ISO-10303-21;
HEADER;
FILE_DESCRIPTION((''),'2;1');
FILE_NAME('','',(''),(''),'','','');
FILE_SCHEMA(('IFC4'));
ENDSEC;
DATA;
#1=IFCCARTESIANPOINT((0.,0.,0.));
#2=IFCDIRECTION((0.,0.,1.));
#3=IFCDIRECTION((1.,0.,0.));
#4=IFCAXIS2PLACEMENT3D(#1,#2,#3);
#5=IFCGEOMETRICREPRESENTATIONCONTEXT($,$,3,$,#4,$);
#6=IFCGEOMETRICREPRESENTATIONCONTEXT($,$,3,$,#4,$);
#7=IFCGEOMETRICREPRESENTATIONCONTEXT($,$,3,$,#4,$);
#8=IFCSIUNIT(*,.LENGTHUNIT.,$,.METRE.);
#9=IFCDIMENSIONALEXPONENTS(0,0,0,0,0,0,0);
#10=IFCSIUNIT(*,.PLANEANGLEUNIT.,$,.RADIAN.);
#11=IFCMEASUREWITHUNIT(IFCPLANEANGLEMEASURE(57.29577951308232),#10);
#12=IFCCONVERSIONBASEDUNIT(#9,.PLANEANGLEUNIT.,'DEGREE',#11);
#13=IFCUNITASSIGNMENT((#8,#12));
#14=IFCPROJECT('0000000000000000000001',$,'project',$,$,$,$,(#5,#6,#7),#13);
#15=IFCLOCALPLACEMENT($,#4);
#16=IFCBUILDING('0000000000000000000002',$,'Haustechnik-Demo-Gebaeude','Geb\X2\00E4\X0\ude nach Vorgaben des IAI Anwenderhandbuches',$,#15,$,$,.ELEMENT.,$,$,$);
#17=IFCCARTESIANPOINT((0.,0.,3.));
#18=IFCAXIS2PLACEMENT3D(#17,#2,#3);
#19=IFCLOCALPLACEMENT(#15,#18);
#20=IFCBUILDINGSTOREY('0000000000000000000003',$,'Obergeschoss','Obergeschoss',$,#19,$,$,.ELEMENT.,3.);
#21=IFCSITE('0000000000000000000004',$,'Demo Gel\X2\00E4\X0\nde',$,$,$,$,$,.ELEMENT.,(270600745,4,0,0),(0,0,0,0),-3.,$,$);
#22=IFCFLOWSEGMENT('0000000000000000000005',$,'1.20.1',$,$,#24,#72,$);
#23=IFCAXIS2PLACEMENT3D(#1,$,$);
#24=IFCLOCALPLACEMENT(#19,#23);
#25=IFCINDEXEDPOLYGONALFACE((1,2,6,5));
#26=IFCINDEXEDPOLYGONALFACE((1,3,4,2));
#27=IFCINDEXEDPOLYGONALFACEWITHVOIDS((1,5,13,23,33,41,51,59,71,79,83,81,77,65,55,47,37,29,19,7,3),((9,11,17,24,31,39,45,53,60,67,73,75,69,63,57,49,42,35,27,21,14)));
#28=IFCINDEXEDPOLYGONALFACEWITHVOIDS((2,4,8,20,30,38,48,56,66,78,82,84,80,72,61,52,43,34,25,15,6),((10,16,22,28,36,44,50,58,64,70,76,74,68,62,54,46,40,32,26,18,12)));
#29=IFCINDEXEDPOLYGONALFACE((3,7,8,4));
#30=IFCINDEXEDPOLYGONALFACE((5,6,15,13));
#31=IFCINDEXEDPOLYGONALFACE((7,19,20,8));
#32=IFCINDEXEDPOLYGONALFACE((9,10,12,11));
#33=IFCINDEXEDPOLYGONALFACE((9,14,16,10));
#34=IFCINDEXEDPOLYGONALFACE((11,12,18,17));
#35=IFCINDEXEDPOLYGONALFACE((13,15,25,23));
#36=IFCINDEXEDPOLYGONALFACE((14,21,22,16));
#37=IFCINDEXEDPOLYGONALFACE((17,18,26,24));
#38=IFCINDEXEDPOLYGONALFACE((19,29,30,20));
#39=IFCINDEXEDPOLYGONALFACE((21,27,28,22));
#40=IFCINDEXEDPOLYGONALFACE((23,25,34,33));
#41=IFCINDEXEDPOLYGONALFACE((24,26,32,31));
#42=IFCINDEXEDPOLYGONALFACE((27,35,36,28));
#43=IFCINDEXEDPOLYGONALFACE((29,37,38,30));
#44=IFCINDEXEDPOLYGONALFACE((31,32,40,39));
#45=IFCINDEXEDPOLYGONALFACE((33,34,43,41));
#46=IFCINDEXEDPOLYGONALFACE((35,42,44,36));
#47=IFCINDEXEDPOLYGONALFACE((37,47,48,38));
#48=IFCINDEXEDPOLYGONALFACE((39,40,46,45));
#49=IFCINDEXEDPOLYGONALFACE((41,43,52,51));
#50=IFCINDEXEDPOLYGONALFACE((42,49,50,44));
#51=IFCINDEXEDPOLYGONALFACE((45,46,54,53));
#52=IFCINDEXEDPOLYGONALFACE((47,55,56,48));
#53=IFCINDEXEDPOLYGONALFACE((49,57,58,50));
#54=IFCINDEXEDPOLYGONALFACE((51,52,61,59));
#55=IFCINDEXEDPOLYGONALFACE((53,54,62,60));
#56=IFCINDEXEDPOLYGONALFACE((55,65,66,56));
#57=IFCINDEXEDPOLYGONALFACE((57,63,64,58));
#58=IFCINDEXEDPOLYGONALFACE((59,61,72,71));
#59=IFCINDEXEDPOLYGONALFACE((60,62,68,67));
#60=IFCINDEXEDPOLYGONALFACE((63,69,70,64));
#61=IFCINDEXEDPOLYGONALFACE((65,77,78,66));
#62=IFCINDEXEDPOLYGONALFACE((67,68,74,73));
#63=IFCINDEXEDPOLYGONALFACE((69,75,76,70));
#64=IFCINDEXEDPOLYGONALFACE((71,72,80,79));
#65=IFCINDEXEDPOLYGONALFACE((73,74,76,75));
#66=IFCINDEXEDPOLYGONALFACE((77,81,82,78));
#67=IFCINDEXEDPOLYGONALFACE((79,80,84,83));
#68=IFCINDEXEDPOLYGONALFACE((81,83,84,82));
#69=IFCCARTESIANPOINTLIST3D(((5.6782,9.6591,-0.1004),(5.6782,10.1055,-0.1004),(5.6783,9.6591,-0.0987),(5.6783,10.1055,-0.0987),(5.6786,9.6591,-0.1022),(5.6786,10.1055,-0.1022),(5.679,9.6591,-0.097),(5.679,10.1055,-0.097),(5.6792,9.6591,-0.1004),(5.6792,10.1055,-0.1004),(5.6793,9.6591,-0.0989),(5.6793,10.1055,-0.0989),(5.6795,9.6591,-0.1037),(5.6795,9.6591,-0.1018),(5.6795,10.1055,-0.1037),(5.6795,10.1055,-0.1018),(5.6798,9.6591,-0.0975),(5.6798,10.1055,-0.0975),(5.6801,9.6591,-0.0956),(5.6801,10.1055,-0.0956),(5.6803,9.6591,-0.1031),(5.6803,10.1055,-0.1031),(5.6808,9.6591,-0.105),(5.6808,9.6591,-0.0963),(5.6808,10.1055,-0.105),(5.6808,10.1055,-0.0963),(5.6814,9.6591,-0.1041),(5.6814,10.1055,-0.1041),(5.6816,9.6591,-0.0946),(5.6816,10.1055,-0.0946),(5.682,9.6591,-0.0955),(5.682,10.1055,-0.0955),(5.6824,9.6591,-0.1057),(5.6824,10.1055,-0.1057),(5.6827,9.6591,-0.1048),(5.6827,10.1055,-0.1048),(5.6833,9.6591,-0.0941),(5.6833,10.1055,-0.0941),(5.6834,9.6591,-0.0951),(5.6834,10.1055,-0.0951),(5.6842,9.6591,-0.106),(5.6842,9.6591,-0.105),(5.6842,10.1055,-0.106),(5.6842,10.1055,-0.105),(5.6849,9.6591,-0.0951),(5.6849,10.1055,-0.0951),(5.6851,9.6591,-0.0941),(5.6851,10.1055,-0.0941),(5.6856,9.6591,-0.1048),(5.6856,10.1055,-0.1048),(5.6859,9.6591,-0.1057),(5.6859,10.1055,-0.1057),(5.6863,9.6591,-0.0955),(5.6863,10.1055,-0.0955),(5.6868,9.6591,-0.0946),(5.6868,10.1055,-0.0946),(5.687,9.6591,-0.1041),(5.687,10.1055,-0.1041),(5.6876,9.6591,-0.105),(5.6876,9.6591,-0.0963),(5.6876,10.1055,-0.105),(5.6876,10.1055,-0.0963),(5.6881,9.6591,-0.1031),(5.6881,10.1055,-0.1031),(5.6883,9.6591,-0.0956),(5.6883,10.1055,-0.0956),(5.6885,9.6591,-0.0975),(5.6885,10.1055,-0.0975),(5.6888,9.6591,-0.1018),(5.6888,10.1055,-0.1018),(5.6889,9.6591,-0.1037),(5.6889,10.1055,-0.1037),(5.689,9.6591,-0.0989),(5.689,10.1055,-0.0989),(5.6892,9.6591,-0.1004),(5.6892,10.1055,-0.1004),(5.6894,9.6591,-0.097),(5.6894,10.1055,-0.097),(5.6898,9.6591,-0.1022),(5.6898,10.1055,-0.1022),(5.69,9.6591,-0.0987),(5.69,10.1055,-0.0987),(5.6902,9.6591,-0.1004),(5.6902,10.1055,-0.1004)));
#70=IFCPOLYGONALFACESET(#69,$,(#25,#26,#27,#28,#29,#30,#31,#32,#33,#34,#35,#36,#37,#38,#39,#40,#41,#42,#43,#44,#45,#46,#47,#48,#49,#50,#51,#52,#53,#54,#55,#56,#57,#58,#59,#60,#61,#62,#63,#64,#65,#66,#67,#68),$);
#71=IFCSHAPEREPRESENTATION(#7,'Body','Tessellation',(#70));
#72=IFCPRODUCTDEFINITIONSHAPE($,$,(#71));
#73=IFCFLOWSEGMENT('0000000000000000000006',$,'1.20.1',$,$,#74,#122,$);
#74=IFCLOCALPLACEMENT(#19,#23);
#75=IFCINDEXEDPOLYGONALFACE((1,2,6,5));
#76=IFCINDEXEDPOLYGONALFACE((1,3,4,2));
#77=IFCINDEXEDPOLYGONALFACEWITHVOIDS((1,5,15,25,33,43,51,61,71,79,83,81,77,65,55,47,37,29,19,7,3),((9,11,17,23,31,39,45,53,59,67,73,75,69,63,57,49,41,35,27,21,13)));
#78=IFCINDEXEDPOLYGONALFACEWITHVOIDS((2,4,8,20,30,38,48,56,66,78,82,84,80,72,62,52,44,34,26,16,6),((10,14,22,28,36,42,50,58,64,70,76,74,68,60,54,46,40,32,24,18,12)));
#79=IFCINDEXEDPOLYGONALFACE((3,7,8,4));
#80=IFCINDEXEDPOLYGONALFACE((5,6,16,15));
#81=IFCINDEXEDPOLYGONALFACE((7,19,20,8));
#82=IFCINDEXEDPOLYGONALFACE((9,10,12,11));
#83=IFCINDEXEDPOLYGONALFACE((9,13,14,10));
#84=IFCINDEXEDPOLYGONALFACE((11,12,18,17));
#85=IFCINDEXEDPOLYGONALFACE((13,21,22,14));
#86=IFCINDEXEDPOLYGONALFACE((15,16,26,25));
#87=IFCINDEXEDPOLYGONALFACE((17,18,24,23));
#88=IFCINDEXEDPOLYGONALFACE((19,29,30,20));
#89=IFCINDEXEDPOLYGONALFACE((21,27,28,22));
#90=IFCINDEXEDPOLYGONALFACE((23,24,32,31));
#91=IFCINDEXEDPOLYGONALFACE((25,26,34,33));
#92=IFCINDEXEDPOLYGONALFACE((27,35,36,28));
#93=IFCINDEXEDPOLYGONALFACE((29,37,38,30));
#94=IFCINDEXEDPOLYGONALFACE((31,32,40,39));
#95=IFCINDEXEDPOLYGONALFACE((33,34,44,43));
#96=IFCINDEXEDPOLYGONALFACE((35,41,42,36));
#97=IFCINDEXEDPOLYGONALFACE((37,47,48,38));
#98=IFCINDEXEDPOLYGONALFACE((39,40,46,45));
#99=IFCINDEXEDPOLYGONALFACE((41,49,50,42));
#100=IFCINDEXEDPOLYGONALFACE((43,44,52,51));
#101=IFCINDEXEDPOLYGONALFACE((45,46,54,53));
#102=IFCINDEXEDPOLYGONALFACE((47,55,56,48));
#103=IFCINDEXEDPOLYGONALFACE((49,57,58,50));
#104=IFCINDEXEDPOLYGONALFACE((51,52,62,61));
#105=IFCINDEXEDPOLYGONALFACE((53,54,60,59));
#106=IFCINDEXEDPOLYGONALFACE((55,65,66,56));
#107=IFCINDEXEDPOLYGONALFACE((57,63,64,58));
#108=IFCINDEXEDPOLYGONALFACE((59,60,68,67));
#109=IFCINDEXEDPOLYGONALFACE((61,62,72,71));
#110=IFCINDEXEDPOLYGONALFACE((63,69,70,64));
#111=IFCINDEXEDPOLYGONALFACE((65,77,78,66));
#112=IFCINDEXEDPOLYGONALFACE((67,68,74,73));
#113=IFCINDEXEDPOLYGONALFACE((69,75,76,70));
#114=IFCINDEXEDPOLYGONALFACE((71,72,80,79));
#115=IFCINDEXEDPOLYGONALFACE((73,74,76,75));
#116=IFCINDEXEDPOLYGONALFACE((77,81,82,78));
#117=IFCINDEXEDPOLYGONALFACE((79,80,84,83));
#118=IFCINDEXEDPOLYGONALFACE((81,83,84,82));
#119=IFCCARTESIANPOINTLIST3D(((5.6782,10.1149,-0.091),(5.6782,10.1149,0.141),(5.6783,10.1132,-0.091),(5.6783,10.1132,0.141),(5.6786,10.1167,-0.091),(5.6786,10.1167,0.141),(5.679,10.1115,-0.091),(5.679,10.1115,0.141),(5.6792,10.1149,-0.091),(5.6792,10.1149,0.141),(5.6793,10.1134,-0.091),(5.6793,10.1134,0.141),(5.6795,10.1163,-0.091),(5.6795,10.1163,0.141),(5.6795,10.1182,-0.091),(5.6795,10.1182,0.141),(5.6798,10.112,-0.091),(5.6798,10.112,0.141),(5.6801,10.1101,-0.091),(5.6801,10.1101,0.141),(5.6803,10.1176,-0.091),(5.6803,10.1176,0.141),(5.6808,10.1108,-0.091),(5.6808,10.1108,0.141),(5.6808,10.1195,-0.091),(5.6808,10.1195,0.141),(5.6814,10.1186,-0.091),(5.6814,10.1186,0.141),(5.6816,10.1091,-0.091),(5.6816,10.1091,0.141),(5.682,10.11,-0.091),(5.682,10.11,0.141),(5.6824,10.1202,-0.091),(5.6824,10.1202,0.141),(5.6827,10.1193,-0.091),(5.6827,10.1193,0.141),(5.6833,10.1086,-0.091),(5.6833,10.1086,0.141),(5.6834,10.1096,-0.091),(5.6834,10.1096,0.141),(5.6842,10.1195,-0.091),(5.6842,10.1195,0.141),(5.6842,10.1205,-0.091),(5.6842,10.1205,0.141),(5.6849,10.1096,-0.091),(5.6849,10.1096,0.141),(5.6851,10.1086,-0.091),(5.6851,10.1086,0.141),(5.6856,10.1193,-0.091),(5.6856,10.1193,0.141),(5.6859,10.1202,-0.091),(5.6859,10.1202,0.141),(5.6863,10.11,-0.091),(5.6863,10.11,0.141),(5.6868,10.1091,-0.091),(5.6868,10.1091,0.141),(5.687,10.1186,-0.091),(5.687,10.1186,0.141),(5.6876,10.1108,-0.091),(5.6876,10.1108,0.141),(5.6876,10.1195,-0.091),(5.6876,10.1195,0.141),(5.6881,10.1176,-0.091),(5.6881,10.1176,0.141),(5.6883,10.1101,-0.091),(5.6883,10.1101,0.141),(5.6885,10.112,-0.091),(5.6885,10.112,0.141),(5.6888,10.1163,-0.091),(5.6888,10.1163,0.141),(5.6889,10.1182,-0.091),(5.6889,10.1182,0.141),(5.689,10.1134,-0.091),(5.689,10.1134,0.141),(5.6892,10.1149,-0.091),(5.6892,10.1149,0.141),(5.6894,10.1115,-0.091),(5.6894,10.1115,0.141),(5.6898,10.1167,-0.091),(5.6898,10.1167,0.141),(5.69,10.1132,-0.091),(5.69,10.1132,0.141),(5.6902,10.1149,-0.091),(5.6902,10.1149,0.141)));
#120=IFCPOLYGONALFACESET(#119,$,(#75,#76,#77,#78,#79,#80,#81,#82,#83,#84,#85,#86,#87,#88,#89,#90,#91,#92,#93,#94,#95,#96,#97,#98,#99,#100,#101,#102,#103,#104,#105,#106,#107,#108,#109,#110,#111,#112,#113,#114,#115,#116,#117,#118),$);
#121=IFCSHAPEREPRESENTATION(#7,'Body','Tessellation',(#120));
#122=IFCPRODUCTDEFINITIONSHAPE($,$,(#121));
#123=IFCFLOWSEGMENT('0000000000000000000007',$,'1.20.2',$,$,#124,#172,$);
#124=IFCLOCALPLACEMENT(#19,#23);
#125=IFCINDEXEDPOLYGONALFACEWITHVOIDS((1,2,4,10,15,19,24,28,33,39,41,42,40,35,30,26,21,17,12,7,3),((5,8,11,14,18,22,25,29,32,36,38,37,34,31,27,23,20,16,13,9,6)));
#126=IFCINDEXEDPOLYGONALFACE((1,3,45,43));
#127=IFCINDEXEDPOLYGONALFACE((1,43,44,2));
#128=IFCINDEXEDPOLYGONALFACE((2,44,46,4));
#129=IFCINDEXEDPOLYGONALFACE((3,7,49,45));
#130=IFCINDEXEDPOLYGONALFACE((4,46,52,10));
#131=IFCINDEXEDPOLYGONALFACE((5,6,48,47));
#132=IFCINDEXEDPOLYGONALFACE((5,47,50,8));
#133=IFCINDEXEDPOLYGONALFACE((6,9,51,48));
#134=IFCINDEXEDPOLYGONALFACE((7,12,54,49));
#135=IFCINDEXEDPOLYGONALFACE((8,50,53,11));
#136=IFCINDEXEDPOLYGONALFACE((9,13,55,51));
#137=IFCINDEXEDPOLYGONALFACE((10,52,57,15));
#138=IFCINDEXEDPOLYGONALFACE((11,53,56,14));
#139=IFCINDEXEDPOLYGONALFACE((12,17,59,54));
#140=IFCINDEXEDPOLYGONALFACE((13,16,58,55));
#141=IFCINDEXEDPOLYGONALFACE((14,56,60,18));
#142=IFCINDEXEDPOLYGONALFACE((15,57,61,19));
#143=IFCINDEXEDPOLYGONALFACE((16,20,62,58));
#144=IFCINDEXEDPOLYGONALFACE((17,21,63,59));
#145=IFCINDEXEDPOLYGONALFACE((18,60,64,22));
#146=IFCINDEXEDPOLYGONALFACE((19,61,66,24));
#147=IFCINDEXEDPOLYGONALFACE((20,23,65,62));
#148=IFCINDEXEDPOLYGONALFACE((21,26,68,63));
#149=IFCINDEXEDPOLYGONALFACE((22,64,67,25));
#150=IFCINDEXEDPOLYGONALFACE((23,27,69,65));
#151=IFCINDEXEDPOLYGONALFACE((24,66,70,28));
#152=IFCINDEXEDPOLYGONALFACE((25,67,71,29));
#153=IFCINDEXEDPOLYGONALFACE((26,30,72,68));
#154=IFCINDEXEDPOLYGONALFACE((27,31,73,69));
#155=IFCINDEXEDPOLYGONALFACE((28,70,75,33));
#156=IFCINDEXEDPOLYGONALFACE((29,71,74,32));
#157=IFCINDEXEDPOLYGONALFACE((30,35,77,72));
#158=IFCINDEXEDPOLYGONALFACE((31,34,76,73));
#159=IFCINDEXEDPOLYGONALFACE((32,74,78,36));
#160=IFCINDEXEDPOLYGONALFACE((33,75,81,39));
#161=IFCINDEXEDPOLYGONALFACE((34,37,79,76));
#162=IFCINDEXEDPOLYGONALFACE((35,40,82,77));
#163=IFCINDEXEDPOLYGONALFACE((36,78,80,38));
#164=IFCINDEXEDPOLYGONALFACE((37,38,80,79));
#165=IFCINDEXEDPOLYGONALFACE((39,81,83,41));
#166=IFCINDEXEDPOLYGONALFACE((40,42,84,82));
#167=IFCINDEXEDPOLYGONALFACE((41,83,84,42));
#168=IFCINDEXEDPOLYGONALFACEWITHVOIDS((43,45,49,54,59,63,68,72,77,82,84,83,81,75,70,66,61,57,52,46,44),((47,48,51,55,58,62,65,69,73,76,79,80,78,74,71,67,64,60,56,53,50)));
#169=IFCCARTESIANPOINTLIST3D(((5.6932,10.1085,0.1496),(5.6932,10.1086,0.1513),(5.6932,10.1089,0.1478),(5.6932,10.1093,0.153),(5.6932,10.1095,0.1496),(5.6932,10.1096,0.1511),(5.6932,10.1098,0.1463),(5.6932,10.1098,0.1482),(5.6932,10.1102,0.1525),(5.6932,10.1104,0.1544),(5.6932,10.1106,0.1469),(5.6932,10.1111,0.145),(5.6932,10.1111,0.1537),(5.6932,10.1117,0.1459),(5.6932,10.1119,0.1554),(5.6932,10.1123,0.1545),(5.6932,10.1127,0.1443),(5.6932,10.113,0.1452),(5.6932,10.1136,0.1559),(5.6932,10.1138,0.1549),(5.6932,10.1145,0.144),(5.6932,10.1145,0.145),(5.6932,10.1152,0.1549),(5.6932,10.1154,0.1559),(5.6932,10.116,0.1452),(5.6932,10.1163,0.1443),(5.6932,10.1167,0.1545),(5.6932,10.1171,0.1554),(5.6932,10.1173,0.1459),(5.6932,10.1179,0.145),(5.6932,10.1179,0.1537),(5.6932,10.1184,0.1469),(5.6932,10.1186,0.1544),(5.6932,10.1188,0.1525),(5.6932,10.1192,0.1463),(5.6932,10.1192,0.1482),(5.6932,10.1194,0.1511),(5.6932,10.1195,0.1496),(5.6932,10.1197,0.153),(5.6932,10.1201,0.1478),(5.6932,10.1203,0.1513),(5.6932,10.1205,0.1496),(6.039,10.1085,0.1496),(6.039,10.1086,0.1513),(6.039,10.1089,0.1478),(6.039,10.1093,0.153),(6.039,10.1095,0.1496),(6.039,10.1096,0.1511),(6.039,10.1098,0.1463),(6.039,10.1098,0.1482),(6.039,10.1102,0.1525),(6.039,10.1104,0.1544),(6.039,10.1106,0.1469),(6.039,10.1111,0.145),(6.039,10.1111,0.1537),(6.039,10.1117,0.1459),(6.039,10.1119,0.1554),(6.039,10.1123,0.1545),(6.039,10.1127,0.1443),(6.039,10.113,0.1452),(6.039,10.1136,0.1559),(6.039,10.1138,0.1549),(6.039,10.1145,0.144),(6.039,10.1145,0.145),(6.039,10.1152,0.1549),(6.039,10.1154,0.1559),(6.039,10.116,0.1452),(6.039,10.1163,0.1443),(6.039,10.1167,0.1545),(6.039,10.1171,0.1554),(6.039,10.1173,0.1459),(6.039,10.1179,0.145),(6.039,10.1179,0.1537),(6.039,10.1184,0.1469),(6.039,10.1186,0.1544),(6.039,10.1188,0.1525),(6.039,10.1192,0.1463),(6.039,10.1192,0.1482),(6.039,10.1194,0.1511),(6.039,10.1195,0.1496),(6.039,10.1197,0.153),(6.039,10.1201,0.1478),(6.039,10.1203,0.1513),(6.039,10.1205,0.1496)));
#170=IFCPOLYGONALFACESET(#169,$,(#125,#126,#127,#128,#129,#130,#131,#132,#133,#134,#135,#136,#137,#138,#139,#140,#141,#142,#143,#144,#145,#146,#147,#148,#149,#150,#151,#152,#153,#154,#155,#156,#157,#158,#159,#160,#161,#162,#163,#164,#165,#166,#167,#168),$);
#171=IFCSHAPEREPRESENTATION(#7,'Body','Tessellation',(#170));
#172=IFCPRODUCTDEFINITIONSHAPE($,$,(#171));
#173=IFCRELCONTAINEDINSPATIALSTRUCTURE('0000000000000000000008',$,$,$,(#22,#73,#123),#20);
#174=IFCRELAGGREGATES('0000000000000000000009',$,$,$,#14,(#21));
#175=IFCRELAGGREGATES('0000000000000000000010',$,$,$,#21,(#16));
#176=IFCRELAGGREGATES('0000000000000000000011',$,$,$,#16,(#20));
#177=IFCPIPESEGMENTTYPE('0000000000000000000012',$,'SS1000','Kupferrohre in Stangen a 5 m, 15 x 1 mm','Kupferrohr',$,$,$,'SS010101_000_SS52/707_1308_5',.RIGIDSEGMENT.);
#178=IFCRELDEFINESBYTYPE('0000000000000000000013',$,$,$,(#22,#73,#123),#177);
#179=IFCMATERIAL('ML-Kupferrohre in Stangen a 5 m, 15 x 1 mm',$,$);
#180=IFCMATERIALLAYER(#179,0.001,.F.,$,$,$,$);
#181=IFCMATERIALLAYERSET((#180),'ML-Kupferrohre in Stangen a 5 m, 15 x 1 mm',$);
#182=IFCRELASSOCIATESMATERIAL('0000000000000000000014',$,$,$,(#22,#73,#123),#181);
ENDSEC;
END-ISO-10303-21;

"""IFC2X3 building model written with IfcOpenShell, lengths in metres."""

from ifc_helpers import new_model, entity, si_unit, converted_unit, frame, origin_with_axes, origin_2d_with_axis, place, context, project, spatial, hollow_circle, extrude, material, layer, layer_set, layer_usage, type_object, element, save


model = new_model("IFC2X3")

# Units and contexts
context_of_model_1 = context(None, 3, world=origin_with_axes())
context_of_model_2 = context(None, 3, world=origin_with_axes())
context_of_model_3 = context(None, 3, world=origin_with_axes())
ifc_project = project(units=[si_unit("LENGTHUNIT", "METRE"), converted_unit("PLANEANGLEUNIT", "DEGREE", entity("IfcPlaneAngleMeasure", 57.29577951308232), si_unit("PLANEANGLEUNIT", "RADIAN"), dimensions=[0, 0, 0, 0, 0, 0, 0])], contexts=[context_of_model_1, context_of_model_2, context_of_model_3])

# Site, building, storey
site = spatial("IfcSite", under=ifc_project, Name="Demo Gelände", CompositionType="ELEMENT", RefLatitude=(270600745, 4, 0, 0), RefLongitude=(0, 0, 0, 0), RefElevation=-3.0)
building_placement = place(None, origin_with_axes())
building = spatial("IfcBuilding", under=site, at=building_placement, Name="Haustechnik-Demo-Gebaeude", Description="Gebäude nach Vorgaben des IAI Anwenderhandbuches", CompositionType="ELEMENT")
storey_placement = place(building_placement, frame((0.0, 0.0, 3.0), z_axis=(0.0, 0.0, 1.0), x_axis=(1.0, 0.0, 0.0)))
storey = spatial("IfcBuildingStorey", under=building, at=storey_placement, Name="Obergeschoss", Description="Obergeschoss", CompositionType="ELEMENT", Elevation=3.0)

# Flow segments
ifc_material_1 = material(Name="ML-Kupferrohre in Stangen a 5 m, 15 x 1 mm")
ifc_layer_1 = layer(ifc_material_1, 0.001, ventilated=False)
ifc_layer_set_1 = layer_set([ifc_layer_1], Name="ML-Kupferrohre in Stangen a 5 m, 15 x 1 mm")
ifc_layer_usage_1 = layer_usage(ifc_layer_set_1, "AXIS2", "POSITIVE", 0.0)
pipe_segment_type_1 = type_object("IfcPipeSegmentType", Name="SS1000", Description="Kupferrohre in Stangen a 5 m, 15 x 1 mm", ApplicableOccurrence="Kupferrohr", ElementType="SS010101_000_SS52/707_1308_5", PredefinedType="RIGIDSEGMENT")
flow_segment_1_placement = place(storey_placement, frame((5.6842, 9.6591, -0.1), z_axis=(0.0, 1.0, 0.0), x_axis=(0.0, 0.0, -1.0)))
element("IfcFlowSegment", 1, at=flow_segment_1_placement, inside=storey, type_object=pipe_segment_type_1, material=ifc_layer_usage_1, Name="1.20.1", context=context_of_model_3, shape_type="SweptSolid", body=[
    extrude(hollow_circle(Radius=0.006, WallThickness=0.001, at=origin_2d_with_axis()), origin_with_axes(), (0.0, 0.0, 1.0), 0.4464),
])
flow_segment_2_placement = place(storey_placement, frame((5.6842, 10.1145, -0.091), z_axis=(0.0, 0.0, 1.0), x_axis=(0.0, 1.0, 0.0)))
element("IfcFlowSegment", 2, at=flow_segment_2_placement, inside=storey, type_object=pipe_segment_type_1, material=ifc_layer_usage_1, Name="1.20.1", context=context_of_model_3, shape_type="SweptSolid", body=[
    extrude(hollow_circle(Radius=0.006, WallThickness=0.001, at=origin_2d_with_axis()), origin_with_axes(), (0.0, 0.0, 1.0), 0.232),
])
flow_segment_3_placement = place(storey_placement, frame((5.6932, 10.1145, 0.15), z_axis=(1.0, 0.0, 0.0), x_axis=(0.0, 0.0, -1.0)))
element("IfcFlowSegment", 3, at=flow_segment_3_placement, inside=storey, type_object=pipe_segment_type_1, material=ifc_layer_usage_1, Name="1.20.2", context=context_of_model_3, shape_type="SweptSolid", body=[
    extrude(hollow_circle(Radius=0.006, WallThickness=0.001, at=origin_2d_with_axis()), origin_with_axes(), (0.0, 0.0, 1.0), 0.3458),
])

save(model, "model.ifc")
